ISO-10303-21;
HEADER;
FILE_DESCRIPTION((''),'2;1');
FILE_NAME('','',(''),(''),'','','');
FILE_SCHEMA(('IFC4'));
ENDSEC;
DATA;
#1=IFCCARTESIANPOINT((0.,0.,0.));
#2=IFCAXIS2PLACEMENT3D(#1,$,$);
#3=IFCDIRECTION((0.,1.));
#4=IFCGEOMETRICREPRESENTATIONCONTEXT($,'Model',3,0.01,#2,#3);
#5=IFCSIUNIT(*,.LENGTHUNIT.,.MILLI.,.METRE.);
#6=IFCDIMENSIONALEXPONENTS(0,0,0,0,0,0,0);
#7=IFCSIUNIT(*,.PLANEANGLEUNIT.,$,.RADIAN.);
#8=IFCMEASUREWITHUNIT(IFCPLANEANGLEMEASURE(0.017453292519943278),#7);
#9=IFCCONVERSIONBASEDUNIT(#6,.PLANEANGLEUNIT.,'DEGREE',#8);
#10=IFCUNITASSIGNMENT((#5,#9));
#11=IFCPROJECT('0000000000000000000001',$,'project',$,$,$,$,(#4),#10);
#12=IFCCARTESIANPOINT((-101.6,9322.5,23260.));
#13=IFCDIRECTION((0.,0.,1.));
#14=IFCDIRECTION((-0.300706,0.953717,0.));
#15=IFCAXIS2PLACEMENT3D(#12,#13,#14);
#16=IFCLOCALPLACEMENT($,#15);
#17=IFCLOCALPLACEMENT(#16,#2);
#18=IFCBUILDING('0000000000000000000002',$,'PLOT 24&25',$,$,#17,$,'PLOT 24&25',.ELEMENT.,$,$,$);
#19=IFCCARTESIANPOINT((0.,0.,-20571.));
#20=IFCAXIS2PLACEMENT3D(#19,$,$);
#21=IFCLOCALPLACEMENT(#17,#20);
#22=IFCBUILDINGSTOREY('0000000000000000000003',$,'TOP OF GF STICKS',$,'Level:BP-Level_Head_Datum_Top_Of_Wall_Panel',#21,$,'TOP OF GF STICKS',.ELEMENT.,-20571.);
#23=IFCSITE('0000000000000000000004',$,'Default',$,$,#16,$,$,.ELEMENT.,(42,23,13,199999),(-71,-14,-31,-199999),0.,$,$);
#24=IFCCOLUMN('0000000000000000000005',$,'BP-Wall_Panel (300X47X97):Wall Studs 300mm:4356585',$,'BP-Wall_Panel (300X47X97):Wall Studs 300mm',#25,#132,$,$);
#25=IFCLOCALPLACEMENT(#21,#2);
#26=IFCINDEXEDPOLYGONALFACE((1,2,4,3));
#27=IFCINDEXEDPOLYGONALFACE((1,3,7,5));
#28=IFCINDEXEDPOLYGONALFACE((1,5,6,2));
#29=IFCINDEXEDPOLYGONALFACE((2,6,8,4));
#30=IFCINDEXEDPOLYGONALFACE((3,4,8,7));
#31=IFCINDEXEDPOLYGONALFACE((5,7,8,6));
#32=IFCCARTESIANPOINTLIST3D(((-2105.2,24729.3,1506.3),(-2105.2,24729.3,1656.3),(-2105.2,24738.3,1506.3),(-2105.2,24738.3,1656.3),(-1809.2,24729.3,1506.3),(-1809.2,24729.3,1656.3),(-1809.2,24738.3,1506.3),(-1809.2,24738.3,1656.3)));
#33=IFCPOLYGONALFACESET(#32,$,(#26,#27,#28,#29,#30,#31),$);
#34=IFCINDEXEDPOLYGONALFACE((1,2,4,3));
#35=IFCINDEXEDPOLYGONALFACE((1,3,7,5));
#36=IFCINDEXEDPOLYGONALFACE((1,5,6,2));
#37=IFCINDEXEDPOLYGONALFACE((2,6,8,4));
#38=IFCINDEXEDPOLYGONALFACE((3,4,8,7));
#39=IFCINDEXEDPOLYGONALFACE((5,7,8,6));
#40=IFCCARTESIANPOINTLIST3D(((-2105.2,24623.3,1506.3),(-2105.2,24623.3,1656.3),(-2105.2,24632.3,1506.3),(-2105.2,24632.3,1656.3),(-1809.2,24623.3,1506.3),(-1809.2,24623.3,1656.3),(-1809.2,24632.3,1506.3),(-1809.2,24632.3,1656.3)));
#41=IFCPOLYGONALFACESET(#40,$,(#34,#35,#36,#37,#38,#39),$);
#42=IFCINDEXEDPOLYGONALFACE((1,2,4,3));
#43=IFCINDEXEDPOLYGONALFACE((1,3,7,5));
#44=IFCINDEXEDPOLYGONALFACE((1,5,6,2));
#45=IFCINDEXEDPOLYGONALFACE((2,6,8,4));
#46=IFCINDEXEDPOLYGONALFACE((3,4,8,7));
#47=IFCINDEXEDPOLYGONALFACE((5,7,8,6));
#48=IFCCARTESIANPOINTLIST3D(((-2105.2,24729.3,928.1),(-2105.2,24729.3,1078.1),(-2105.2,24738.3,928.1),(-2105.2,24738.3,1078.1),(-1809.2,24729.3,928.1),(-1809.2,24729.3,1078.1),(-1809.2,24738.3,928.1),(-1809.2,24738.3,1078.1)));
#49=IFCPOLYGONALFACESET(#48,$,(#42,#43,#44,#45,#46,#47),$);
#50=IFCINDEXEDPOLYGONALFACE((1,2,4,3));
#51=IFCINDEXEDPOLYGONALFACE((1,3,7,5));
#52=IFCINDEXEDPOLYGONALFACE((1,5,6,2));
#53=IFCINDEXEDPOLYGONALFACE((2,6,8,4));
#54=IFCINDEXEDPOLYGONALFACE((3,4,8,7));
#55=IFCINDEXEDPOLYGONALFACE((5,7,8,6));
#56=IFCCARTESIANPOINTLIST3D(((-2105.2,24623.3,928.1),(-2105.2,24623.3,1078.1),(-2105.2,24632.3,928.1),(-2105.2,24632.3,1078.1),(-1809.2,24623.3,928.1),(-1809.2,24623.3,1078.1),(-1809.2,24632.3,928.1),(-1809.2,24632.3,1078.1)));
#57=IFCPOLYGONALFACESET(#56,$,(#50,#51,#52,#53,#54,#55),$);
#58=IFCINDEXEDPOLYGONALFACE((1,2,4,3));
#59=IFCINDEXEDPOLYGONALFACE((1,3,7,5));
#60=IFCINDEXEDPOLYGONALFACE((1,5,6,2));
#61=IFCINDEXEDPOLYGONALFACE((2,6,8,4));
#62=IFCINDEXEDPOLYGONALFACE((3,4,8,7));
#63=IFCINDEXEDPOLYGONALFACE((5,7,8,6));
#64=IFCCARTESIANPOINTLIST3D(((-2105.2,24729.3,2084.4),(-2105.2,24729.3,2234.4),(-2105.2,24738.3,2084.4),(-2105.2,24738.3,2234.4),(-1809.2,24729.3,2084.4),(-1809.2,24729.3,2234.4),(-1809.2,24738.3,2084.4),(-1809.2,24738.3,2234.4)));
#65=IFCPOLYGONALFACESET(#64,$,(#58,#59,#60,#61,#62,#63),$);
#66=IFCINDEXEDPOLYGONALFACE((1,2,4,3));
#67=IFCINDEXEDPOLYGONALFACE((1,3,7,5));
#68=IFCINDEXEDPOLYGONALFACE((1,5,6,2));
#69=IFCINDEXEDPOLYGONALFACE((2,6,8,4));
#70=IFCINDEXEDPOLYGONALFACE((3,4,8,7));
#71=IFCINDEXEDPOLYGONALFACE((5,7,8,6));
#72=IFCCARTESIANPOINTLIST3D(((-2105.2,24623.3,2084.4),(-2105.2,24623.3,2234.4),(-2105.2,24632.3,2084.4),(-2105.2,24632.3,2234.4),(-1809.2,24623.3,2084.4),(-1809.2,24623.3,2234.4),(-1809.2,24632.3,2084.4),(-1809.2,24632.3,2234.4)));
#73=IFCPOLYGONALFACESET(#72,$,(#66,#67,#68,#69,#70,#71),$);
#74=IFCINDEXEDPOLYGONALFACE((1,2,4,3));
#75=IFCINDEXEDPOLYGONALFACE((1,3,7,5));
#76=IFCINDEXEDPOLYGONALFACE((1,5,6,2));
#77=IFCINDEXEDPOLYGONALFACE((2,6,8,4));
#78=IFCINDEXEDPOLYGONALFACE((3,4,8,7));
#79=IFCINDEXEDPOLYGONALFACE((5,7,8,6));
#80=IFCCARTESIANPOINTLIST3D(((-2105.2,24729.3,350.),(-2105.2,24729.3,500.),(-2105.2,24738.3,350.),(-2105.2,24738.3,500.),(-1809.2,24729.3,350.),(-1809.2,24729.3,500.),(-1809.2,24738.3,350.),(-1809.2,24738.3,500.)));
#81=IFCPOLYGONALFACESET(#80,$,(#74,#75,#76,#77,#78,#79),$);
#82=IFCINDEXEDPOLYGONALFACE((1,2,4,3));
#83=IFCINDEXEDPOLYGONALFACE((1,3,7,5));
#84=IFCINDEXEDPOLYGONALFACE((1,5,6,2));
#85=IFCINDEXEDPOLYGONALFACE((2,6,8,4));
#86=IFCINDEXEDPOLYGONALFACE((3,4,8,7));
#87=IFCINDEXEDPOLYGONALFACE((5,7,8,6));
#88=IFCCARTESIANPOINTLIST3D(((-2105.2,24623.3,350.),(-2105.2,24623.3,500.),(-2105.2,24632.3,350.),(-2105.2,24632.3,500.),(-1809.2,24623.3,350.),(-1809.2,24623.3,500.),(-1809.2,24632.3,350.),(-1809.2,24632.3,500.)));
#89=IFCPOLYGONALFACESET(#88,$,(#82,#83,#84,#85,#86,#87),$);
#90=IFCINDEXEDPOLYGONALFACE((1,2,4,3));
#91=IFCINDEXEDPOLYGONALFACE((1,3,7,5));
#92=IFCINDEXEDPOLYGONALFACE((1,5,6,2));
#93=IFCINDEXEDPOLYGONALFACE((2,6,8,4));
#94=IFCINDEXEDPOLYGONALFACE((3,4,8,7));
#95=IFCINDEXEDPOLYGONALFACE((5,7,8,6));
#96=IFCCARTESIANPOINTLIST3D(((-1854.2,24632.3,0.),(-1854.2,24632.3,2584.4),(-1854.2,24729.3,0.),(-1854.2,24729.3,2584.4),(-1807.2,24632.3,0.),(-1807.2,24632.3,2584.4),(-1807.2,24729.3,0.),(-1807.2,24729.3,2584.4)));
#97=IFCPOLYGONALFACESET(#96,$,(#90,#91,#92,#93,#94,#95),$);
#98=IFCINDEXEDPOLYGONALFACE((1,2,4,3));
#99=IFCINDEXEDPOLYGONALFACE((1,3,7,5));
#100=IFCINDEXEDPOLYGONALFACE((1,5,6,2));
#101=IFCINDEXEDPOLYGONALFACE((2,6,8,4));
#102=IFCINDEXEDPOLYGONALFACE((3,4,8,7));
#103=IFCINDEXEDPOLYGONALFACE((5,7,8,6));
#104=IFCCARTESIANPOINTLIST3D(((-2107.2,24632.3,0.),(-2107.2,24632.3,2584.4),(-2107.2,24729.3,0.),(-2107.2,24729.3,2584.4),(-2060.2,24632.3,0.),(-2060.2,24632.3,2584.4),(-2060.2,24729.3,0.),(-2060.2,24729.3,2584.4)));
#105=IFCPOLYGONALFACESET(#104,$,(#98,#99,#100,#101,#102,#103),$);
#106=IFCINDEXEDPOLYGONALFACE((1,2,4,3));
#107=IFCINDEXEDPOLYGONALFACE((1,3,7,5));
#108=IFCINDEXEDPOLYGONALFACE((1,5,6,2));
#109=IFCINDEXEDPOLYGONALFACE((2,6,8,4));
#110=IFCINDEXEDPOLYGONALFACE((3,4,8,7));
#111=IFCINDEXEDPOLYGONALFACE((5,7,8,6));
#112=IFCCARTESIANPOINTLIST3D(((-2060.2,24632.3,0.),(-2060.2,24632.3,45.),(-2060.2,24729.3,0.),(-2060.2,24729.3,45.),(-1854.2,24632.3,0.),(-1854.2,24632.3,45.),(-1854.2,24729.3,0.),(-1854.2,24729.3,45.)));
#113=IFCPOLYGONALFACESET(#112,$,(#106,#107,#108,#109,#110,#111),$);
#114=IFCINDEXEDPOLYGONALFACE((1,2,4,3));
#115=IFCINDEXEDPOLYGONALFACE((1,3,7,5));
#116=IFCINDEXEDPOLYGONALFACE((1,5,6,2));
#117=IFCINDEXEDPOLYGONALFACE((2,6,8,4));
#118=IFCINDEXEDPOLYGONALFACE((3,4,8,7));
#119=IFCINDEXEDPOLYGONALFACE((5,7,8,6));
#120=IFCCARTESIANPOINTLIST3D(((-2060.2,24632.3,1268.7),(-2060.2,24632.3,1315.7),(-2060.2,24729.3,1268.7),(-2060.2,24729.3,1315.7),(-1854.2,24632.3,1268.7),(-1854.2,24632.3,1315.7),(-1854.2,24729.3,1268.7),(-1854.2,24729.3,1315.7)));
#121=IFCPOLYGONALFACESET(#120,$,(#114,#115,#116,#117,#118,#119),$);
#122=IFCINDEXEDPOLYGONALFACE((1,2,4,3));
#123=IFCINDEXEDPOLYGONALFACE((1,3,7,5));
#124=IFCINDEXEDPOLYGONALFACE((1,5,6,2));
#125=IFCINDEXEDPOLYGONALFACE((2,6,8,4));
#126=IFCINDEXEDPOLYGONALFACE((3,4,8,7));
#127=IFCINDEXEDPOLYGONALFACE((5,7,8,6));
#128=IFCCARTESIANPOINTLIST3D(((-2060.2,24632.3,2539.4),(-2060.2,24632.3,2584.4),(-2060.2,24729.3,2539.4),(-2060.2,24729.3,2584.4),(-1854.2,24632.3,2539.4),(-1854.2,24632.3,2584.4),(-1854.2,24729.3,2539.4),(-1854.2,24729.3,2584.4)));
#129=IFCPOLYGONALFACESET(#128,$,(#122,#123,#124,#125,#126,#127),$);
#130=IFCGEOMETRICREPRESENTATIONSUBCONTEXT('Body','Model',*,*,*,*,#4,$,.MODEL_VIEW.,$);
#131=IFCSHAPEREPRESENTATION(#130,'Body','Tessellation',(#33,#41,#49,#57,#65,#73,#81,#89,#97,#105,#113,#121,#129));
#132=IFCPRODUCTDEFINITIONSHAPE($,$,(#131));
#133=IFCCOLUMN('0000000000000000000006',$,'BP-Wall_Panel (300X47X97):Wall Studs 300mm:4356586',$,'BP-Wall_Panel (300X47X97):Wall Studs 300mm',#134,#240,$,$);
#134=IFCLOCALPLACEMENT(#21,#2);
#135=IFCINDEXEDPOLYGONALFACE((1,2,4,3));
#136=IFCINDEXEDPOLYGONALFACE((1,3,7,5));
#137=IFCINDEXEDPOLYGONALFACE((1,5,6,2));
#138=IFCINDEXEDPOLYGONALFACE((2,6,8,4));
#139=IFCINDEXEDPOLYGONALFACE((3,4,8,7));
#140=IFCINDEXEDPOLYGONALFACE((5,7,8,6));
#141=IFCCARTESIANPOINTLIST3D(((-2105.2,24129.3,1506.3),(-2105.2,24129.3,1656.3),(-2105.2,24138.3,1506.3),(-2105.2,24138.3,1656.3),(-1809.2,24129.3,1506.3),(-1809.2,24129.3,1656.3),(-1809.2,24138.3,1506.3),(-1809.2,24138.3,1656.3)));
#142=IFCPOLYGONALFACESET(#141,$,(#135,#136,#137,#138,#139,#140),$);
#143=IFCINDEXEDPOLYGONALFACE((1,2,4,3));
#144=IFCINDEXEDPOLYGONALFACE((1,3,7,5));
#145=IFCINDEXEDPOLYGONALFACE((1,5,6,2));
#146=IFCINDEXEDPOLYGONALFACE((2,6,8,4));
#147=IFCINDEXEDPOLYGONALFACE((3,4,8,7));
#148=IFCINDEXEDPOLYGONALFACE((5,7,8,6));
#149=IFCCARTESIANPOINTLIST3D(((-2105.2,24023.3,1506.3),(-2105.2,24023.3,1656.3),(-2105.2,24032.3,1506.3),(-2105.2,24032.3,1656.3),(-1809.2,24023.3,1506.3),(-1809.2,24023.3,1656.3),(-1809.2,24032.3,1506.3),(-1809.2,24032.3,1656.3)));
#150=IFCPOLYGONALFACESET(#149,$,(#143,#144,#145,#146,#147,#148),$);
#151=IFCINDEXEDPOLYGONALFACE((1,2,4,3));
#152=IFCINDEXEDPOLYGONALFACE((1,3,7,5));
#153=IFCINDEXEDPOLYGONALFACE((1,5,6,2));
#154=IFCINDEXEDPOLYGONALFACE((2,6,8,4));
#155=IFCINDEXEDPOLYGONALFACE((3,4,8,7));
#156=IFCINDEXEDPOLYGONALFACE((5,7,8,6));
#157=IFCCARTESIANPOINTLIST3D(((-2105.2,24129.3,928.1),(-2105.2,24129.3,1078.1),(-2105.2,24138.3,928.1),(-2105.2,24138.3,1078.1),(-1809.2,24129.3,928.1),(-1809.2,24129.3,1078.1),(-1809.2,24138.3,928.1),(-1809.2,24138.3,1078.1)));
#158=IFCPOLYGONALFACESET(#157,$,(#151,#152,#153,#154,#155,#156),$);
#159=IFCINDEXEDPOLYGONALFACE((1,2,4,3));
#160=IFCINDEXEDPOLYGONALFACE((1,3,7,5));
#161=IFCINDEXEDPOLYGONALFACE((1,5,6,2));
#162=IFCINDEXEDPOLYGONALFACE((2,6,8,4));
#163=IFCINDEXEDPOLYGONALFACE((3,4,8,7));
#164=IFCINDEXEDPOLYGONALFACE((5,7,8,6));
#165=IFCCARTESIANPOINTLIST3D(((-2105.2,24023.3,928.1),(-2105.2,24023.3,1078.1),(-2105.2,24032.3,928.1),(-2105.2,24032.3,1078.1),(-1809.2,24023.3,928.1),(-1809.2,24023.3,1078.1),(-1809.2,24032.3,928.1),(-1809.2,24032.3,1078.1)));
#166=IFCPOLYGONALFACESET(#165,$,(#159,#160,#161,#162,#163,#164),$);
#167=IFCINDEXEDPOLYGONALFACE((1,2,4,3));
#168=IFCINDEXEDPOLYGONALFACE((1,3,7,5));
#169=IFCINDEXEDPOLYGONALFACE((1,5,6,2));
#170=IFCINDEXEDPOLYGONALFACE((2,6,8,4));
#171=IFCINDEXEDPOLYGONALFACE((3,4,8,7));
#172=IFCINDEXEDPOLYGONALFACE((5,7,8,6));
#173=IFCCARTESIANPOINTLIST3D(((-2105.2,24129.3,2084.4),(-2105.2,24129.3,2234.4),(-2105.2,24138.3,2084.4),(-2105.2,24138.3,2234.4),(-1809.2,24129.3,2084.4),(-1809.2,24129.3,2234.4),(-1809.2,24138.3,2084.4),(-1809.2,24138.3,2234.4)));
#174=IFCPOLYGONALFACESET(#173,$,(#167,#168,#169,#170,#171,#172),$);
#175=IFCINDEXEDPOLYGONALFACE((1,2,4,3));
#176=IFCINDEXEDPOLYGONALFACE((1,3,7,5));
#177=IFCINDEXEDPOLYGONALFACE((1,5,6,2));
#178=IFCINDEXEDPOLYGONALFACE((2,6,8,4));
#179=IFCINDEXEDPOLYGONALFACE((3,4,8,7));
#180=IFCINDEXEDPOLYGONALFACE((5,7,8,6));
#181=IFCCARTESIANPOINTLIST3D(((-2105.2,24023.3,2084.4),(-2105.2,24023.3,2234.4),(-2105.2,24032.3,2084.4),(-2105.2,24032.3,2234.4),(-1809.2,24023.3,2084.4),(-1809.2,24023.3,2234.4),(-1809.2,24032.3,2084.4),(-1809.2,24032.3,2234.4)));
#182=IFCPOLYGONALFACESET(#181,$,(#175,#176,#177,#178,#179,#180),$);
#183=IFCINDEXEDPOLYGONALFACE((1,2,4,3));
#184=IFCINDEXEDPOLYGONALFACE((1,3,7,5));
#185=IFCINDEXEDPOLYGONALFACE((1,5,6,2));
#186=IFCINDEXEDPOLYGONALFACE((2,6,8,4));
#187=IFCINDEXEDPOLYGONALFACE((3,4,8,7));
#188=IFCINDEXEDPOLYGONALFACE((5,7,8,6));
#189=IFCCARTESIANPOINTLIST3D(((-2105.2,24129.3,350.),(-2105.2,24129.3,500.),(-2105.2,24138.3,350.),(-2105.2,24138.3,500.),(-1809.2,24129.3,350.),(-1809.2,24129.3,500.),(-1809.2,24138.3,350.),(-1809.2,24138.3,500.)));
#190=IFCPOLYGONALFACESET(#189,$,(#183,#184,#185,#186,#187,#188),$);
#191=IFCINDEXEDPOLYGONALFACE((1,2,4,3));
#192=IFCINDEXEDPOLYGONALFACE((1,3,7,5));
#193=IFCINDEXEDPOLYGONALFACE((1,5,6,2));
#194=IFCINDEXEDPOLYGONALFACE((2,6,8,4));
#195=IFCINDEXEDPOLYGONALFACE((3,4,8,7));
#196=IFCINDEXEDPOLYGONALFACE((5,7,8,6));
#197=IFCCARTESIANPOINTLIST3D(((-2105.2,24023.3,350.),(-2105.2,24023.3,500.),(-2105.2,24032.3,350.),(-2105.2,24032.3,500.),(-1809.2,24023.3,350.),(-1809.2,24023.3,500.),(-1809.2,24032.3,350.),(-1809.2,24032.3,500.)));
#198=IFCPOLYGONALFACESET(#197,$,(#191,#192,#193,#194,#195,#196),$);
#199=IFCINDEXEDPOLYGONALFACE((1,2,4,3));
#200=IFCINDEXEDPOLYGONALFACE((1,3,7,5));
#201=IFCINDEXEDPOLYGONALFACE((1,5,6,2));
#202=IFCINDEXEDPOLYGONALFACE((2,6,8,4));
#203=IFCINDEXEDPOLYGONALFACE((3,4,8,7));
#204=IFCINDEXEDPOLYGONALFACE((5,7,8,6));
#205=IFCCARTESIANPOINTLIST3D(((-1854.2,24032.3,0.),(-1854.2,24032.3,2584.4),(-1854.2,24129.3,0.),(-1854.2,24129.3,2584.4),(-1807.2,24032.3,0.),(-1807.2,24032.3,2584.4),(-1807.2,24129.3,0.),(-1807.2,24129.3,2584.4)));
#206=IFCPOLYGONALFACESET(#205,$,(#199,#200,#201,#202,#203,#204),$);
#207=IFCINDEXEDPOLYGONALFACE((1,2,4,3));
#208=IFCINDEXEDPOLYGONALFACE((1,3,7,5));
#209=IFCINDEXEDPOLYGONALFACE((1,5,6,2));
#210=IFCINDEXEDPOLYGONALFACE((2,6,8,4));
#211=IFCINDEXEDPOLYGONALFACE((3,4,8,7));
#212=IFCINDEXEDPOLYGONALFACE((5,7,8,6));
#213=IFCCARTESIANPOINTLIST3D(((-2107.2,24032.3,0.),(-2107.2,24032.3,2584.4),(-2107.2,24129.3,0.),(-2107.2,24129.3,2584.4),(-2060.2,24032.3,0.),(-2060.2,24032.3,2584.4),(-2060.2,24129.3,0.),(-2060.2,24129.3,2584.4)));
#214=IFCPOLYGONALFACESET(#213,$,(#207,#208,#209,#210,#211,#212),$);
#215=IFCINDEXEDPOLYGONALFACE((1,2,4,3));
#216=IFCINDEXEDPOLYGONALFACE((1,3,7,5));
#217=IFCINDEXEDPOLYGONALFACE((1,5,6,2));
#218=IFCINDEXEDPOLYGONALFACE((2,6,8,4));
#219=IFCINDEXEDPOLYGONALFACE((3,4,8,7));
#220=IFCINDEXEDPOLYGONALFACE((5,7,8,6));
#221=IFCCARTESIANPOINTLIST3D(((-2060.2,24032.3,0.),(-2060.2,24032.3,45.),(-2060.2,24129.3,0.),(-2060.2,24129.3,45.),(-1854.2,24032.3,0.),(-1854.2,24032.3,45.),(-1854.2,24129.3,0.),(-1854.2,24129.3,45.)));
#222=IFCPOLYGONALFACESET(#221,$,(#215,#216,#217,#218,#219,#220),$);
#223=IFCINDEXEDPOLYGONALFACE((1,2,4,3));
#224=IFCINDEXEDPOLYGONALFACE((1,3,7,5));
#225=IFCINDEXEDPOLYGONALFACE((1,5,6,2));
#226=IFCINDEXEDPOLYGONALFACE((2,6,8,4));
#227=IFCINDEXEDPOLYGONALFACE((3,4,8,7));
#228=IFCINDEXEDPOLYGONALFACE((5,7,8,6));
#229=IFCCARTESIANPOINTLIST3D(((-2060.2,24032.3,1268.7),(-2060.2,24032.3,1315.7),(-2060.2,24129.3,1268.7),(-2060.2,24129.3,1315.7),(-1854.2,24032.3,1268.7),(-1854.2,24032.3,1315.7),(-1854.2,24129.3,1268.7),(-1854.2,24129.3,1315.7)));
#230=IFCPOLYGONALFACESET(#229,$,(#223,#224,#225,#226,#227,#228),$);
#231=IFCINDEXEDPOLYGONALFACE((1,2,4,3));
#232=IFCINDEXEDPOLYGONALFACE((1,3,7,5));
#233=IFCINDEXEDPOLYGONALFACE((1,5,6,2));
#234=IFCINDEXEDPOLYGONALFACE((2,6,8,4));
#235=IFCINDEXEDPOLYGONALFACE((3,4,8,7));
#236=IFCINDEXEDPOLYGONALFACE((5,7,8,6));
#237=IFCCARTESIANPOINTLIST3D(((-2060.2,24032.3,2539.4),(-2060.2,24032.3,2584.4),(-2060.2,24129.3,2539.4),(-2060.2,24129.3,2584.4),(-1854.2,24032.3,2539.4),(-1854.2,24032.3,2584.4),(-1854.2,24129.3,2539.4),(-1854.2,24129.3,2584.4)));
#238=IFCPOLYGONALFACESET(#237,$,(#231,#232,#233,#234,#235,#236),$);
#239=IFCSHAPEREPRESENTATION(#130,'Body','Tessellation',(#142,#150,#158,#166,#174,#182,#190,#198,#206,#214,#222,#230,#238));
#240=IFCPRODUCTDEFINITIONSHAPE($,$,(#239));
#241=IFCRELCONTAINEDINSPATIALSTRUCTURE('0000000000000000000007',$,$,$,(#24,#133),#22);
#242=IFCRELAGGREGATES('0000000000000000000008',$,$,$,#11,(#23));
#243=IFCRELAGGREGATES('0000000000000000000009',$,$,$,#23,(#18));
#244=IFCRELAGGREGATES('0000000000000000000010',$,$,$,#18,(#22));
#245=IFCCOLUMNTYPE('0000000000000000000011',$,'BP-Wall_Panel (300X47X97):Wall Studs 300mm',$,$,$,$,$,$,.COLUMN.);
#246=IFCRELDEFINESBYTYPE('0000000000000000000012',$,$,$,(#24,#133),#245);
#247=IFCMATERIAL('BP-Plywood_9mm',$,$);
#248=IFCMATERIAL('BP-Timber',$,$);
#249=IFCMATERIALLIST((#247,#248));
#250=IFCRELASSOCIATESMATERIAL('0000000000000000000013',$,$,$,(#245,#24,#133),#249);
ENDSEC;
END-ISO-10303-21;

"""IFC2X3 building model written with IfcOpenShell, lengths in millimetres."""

from ifc_helpers import new_model, entity, si_unit, converted_unit, direction, frame, frame_2d, origin, origin_2d_with_axis, place, context, subcontext, project, spatial, rectangle, extrude, source, transform, mapped, material, material_list, type_object, type_shapes, element, save


model = new_model("IFC2X3")

# Units and contexts
model_context = context("Model", 3, precision=0.01, world=origin(), true_north=direction((0.0, 1.0)))
body_context = subcontext(model_context, "Body", "Model", "MODEL_VIEW")
ifc_project = project(units=[si_unit("LENGTHUNIT", "METRE", prefix="MILLI"), converted_unit("PLANEANGLEUNIT", "DEGREE", entity("IfcPlaneAngleMeasure", 0.017453292519943278), si_unit("PLANEANGLEUNIT", "RADIAN"), dimensions=[0, 0, 0, 0, 0, 0, 0])], contexts=[model_context])

# Site, building, storey
site_placement = place(None, frame((-101.6, 9322.5, 23260.0), z_axis=(0.0, 0.0, 1.0), x_axis=(-0.300706, 0.953717, 0.0)))
site = spatial("IfcSite", under=ifc_project, at=site_placement, Name="Default", CompositionType="ELEMENT", RefLatitude=(42, 23, 13, 199999), RefLongitude=(-71, -14, -31, -199999), RefElevation=0.0)
building_placement = place(site_placement, origin())
building = spatial("IfcBuilding", under=site, at=building_placement, Name="PLOT 24&25", LongName="PLOT 24&25", CompositionType="ELEMENT")
storey_placement = place(building_placement, frame((0.0, 0.0, -20571.0)))
storey = spatial("IfcBuildingStorey", under=building, at=storey_placement, Name="TOP OF GF STICKS", ObjectType="Level:BP-Level_Head_Datum_Top_Of_Wall_Panel", LongName="TOP OF GF STICKS", CompositionType="ELEMENT", Elevation=-20571.0)

# Columns
ifc_material_1 = material(Name="BP-Plywood_9mm")
ifc_material_2 = material(Name="BP-Timber")
ifc_material_list = material_list([ifc_material_1, ifc_material_2])
column_type_1 = type_object("IfcColumnType", Name="BP-Wall_Panel (300X47X97):Wall Studs 300mm", PredefinedType="COLUMN", material=ifc_material_list)
shared_shape_1 = source(origin(), body_context, "Body", "SweptSolid", [
    extrude(rectangle(XDim=296.0, YDim=9.0, at=origin_2d_with_axis()), frame((53.0, 0.0, -19064.7), z_axis=(0.0, 0.0, 1.0), x_axis=(0.0, -1.0, 0.0)), (0.0, 0.0, 1.0), 150.0),
    extrude(rectangle(XDim=9.0, YDim=296.0, at=origin_2d_with_axis()), frame((-53.0, 0.0, -19064.7), z_axis=(0.0, 0.0, 1.0), x_axis=(-1.0, 0.0, 0.0)), (0.0, 0.0, 1.0), 150.0),
    extrude(rectangle(XDim=296.0, YDim=9.0, at=origin_2d_with_axis()), frame((53.0, 0.0, -19642.9), z_axis=(0.0, 0.0, 1.0), x_axis=(0.0, -1.0, 0.0)), (0.0, 0.0, 1.0), 150.0),
    extrude(rectangle(XDim=9.0, YDim=296.0, at=origin_2d_with_axis()), frame((-53.0, 0.0, -19642.9), z_axis=(0.0, 0.0, 1.0), x_axis=(-1.0, 0.0, 0.0)), (0.0, 0.0, 1.0), 150.0),
    extrude(rectangle(XDim=296.0, YDim=9.0, at=origin_2d_with_axis()), frame((53.0, 0.0, -18486.6), z_axis=(0.0, 0.0, 1.0), x_axis=(0.0, -1.0, 0.0)), (0.0, 0.0, 1.0), 150.0),
    extrude(rectangle(XDim=9.0, YDim=296.0, at=origin_2d_with_axis()), frame((-53.0, 0.0, -18486.6), z_axis=(0.0, 0.0, 1.0), x_axis=(-1.0, 0.0, 0.0)), (0.0, 0.0, 1.0), 150.0),
    extrude(rectangle(XDim=296.0, YDim=9.0, at=origin_2d_with_axis()), frame((53.0, 0.0, -20221.0), z_axis=(0.0, 0.0, 1.0), x_axis=(0.0, -1.0, 0.0)), (0.0, 0.0, 1.0), 150.0),
    extrude(rectangle(XDim=9.0, YDim=296.0, at=origin_2d_with_axis()), frame((-53.0, 0.0, -20221.0), z_axis=(0.0, 0.0, 1.0), x_axis=(-1.0, 0.0, 0.0)), (0.0, 0.0, 1.0), 150.0),
    extrude(rectangle(XDim=97.0, YDim=47.0, at=origin_2d_with_axis()), frame((0.0, -126.5, -20571.0), z_axis=(0.0, 0.0, 1.0), x_axis=(-1.0, 0.0, 0.0)), (0.0, 0.0, 1.0), 2584.4),
    extrude(rectangle(XDim=97.0, YDim=47.0, at=frame_2d((0.0, 0.0), x_axis=(1.0, 0.0))), frame((0.0, 126.5, -20571.0), z_axis=(0.0, 0.0, 1.0), x_axis=(-1.0, 0.0, 0.0)), (0.0, 0.0, 1.0), 2584.4),
    extrude(rectangle(XDim=206.0, YDim=97.0, at=origin_2d_with_axis()), frame((0.0, 0.0, -20571.0), z_axis=(0.0, 0.0, 1.0), x_axis=(0.0, -1.0, 0.0)), (0.0, 0.0, 1.0), 45.0),
    extrude(rectangle(XDim=206.0, YDim=97.0, at=origin_2d_with_axis()), frame((0.0, 0.0, -19302.3), z_axis=(0.0, 0.0, 1.0), x_axis=(0.0, -1.0, 0.0)), (0.0, 0.0, 1.0), 47.0),
    extrude(rectangle(XDim=206.0, YDim=97.0, at=origin_2d_with_axis()), frame((0.0, 0.0, -18031.6), z_axis=(0.0, 0.0, 1.0), x_axis=(0.0, -1.0, 0.0)), (0.0, 0.0, 1.0), 45.0),
])
type_shapes(column_type_1, [shared_shape_1])
for number, where, z_axis, x_axis, name in (
    (1, (-1957.2, 24680.8, 20571.0), (0.0, 0.0, 1.0), (0.0, 1.0, 0.0), "BP-Wall_Panel (300X47X97):Wall Studs 300mm:4356585"),
    (2, (-1957.2, 24080.8, 20571.0), (0.0, 0.0, 1.0), (0.0, 1.0, 0.0), "BP-Wall_Panel (300X47X97):Wall Studs 300mm:4356586"),
):
    element("IfcColumn", number, at=place(storey_placement, frame(where, z_axis=z_axis, x_axis=x_axis)), inside=storey, type_object=column_type_1, material=ifc_material_list, Name=name, ObjectType="BP-Wall_Panel (300X47X97):Wall Studs 300mm", context=body_context, shape_type="MappedRepresentation", body=[
        mapped(shared_shape_1, transform((0.0, 0.0, 0.0), scale=1.0)),
    ])

save(model, "model.ifc")
